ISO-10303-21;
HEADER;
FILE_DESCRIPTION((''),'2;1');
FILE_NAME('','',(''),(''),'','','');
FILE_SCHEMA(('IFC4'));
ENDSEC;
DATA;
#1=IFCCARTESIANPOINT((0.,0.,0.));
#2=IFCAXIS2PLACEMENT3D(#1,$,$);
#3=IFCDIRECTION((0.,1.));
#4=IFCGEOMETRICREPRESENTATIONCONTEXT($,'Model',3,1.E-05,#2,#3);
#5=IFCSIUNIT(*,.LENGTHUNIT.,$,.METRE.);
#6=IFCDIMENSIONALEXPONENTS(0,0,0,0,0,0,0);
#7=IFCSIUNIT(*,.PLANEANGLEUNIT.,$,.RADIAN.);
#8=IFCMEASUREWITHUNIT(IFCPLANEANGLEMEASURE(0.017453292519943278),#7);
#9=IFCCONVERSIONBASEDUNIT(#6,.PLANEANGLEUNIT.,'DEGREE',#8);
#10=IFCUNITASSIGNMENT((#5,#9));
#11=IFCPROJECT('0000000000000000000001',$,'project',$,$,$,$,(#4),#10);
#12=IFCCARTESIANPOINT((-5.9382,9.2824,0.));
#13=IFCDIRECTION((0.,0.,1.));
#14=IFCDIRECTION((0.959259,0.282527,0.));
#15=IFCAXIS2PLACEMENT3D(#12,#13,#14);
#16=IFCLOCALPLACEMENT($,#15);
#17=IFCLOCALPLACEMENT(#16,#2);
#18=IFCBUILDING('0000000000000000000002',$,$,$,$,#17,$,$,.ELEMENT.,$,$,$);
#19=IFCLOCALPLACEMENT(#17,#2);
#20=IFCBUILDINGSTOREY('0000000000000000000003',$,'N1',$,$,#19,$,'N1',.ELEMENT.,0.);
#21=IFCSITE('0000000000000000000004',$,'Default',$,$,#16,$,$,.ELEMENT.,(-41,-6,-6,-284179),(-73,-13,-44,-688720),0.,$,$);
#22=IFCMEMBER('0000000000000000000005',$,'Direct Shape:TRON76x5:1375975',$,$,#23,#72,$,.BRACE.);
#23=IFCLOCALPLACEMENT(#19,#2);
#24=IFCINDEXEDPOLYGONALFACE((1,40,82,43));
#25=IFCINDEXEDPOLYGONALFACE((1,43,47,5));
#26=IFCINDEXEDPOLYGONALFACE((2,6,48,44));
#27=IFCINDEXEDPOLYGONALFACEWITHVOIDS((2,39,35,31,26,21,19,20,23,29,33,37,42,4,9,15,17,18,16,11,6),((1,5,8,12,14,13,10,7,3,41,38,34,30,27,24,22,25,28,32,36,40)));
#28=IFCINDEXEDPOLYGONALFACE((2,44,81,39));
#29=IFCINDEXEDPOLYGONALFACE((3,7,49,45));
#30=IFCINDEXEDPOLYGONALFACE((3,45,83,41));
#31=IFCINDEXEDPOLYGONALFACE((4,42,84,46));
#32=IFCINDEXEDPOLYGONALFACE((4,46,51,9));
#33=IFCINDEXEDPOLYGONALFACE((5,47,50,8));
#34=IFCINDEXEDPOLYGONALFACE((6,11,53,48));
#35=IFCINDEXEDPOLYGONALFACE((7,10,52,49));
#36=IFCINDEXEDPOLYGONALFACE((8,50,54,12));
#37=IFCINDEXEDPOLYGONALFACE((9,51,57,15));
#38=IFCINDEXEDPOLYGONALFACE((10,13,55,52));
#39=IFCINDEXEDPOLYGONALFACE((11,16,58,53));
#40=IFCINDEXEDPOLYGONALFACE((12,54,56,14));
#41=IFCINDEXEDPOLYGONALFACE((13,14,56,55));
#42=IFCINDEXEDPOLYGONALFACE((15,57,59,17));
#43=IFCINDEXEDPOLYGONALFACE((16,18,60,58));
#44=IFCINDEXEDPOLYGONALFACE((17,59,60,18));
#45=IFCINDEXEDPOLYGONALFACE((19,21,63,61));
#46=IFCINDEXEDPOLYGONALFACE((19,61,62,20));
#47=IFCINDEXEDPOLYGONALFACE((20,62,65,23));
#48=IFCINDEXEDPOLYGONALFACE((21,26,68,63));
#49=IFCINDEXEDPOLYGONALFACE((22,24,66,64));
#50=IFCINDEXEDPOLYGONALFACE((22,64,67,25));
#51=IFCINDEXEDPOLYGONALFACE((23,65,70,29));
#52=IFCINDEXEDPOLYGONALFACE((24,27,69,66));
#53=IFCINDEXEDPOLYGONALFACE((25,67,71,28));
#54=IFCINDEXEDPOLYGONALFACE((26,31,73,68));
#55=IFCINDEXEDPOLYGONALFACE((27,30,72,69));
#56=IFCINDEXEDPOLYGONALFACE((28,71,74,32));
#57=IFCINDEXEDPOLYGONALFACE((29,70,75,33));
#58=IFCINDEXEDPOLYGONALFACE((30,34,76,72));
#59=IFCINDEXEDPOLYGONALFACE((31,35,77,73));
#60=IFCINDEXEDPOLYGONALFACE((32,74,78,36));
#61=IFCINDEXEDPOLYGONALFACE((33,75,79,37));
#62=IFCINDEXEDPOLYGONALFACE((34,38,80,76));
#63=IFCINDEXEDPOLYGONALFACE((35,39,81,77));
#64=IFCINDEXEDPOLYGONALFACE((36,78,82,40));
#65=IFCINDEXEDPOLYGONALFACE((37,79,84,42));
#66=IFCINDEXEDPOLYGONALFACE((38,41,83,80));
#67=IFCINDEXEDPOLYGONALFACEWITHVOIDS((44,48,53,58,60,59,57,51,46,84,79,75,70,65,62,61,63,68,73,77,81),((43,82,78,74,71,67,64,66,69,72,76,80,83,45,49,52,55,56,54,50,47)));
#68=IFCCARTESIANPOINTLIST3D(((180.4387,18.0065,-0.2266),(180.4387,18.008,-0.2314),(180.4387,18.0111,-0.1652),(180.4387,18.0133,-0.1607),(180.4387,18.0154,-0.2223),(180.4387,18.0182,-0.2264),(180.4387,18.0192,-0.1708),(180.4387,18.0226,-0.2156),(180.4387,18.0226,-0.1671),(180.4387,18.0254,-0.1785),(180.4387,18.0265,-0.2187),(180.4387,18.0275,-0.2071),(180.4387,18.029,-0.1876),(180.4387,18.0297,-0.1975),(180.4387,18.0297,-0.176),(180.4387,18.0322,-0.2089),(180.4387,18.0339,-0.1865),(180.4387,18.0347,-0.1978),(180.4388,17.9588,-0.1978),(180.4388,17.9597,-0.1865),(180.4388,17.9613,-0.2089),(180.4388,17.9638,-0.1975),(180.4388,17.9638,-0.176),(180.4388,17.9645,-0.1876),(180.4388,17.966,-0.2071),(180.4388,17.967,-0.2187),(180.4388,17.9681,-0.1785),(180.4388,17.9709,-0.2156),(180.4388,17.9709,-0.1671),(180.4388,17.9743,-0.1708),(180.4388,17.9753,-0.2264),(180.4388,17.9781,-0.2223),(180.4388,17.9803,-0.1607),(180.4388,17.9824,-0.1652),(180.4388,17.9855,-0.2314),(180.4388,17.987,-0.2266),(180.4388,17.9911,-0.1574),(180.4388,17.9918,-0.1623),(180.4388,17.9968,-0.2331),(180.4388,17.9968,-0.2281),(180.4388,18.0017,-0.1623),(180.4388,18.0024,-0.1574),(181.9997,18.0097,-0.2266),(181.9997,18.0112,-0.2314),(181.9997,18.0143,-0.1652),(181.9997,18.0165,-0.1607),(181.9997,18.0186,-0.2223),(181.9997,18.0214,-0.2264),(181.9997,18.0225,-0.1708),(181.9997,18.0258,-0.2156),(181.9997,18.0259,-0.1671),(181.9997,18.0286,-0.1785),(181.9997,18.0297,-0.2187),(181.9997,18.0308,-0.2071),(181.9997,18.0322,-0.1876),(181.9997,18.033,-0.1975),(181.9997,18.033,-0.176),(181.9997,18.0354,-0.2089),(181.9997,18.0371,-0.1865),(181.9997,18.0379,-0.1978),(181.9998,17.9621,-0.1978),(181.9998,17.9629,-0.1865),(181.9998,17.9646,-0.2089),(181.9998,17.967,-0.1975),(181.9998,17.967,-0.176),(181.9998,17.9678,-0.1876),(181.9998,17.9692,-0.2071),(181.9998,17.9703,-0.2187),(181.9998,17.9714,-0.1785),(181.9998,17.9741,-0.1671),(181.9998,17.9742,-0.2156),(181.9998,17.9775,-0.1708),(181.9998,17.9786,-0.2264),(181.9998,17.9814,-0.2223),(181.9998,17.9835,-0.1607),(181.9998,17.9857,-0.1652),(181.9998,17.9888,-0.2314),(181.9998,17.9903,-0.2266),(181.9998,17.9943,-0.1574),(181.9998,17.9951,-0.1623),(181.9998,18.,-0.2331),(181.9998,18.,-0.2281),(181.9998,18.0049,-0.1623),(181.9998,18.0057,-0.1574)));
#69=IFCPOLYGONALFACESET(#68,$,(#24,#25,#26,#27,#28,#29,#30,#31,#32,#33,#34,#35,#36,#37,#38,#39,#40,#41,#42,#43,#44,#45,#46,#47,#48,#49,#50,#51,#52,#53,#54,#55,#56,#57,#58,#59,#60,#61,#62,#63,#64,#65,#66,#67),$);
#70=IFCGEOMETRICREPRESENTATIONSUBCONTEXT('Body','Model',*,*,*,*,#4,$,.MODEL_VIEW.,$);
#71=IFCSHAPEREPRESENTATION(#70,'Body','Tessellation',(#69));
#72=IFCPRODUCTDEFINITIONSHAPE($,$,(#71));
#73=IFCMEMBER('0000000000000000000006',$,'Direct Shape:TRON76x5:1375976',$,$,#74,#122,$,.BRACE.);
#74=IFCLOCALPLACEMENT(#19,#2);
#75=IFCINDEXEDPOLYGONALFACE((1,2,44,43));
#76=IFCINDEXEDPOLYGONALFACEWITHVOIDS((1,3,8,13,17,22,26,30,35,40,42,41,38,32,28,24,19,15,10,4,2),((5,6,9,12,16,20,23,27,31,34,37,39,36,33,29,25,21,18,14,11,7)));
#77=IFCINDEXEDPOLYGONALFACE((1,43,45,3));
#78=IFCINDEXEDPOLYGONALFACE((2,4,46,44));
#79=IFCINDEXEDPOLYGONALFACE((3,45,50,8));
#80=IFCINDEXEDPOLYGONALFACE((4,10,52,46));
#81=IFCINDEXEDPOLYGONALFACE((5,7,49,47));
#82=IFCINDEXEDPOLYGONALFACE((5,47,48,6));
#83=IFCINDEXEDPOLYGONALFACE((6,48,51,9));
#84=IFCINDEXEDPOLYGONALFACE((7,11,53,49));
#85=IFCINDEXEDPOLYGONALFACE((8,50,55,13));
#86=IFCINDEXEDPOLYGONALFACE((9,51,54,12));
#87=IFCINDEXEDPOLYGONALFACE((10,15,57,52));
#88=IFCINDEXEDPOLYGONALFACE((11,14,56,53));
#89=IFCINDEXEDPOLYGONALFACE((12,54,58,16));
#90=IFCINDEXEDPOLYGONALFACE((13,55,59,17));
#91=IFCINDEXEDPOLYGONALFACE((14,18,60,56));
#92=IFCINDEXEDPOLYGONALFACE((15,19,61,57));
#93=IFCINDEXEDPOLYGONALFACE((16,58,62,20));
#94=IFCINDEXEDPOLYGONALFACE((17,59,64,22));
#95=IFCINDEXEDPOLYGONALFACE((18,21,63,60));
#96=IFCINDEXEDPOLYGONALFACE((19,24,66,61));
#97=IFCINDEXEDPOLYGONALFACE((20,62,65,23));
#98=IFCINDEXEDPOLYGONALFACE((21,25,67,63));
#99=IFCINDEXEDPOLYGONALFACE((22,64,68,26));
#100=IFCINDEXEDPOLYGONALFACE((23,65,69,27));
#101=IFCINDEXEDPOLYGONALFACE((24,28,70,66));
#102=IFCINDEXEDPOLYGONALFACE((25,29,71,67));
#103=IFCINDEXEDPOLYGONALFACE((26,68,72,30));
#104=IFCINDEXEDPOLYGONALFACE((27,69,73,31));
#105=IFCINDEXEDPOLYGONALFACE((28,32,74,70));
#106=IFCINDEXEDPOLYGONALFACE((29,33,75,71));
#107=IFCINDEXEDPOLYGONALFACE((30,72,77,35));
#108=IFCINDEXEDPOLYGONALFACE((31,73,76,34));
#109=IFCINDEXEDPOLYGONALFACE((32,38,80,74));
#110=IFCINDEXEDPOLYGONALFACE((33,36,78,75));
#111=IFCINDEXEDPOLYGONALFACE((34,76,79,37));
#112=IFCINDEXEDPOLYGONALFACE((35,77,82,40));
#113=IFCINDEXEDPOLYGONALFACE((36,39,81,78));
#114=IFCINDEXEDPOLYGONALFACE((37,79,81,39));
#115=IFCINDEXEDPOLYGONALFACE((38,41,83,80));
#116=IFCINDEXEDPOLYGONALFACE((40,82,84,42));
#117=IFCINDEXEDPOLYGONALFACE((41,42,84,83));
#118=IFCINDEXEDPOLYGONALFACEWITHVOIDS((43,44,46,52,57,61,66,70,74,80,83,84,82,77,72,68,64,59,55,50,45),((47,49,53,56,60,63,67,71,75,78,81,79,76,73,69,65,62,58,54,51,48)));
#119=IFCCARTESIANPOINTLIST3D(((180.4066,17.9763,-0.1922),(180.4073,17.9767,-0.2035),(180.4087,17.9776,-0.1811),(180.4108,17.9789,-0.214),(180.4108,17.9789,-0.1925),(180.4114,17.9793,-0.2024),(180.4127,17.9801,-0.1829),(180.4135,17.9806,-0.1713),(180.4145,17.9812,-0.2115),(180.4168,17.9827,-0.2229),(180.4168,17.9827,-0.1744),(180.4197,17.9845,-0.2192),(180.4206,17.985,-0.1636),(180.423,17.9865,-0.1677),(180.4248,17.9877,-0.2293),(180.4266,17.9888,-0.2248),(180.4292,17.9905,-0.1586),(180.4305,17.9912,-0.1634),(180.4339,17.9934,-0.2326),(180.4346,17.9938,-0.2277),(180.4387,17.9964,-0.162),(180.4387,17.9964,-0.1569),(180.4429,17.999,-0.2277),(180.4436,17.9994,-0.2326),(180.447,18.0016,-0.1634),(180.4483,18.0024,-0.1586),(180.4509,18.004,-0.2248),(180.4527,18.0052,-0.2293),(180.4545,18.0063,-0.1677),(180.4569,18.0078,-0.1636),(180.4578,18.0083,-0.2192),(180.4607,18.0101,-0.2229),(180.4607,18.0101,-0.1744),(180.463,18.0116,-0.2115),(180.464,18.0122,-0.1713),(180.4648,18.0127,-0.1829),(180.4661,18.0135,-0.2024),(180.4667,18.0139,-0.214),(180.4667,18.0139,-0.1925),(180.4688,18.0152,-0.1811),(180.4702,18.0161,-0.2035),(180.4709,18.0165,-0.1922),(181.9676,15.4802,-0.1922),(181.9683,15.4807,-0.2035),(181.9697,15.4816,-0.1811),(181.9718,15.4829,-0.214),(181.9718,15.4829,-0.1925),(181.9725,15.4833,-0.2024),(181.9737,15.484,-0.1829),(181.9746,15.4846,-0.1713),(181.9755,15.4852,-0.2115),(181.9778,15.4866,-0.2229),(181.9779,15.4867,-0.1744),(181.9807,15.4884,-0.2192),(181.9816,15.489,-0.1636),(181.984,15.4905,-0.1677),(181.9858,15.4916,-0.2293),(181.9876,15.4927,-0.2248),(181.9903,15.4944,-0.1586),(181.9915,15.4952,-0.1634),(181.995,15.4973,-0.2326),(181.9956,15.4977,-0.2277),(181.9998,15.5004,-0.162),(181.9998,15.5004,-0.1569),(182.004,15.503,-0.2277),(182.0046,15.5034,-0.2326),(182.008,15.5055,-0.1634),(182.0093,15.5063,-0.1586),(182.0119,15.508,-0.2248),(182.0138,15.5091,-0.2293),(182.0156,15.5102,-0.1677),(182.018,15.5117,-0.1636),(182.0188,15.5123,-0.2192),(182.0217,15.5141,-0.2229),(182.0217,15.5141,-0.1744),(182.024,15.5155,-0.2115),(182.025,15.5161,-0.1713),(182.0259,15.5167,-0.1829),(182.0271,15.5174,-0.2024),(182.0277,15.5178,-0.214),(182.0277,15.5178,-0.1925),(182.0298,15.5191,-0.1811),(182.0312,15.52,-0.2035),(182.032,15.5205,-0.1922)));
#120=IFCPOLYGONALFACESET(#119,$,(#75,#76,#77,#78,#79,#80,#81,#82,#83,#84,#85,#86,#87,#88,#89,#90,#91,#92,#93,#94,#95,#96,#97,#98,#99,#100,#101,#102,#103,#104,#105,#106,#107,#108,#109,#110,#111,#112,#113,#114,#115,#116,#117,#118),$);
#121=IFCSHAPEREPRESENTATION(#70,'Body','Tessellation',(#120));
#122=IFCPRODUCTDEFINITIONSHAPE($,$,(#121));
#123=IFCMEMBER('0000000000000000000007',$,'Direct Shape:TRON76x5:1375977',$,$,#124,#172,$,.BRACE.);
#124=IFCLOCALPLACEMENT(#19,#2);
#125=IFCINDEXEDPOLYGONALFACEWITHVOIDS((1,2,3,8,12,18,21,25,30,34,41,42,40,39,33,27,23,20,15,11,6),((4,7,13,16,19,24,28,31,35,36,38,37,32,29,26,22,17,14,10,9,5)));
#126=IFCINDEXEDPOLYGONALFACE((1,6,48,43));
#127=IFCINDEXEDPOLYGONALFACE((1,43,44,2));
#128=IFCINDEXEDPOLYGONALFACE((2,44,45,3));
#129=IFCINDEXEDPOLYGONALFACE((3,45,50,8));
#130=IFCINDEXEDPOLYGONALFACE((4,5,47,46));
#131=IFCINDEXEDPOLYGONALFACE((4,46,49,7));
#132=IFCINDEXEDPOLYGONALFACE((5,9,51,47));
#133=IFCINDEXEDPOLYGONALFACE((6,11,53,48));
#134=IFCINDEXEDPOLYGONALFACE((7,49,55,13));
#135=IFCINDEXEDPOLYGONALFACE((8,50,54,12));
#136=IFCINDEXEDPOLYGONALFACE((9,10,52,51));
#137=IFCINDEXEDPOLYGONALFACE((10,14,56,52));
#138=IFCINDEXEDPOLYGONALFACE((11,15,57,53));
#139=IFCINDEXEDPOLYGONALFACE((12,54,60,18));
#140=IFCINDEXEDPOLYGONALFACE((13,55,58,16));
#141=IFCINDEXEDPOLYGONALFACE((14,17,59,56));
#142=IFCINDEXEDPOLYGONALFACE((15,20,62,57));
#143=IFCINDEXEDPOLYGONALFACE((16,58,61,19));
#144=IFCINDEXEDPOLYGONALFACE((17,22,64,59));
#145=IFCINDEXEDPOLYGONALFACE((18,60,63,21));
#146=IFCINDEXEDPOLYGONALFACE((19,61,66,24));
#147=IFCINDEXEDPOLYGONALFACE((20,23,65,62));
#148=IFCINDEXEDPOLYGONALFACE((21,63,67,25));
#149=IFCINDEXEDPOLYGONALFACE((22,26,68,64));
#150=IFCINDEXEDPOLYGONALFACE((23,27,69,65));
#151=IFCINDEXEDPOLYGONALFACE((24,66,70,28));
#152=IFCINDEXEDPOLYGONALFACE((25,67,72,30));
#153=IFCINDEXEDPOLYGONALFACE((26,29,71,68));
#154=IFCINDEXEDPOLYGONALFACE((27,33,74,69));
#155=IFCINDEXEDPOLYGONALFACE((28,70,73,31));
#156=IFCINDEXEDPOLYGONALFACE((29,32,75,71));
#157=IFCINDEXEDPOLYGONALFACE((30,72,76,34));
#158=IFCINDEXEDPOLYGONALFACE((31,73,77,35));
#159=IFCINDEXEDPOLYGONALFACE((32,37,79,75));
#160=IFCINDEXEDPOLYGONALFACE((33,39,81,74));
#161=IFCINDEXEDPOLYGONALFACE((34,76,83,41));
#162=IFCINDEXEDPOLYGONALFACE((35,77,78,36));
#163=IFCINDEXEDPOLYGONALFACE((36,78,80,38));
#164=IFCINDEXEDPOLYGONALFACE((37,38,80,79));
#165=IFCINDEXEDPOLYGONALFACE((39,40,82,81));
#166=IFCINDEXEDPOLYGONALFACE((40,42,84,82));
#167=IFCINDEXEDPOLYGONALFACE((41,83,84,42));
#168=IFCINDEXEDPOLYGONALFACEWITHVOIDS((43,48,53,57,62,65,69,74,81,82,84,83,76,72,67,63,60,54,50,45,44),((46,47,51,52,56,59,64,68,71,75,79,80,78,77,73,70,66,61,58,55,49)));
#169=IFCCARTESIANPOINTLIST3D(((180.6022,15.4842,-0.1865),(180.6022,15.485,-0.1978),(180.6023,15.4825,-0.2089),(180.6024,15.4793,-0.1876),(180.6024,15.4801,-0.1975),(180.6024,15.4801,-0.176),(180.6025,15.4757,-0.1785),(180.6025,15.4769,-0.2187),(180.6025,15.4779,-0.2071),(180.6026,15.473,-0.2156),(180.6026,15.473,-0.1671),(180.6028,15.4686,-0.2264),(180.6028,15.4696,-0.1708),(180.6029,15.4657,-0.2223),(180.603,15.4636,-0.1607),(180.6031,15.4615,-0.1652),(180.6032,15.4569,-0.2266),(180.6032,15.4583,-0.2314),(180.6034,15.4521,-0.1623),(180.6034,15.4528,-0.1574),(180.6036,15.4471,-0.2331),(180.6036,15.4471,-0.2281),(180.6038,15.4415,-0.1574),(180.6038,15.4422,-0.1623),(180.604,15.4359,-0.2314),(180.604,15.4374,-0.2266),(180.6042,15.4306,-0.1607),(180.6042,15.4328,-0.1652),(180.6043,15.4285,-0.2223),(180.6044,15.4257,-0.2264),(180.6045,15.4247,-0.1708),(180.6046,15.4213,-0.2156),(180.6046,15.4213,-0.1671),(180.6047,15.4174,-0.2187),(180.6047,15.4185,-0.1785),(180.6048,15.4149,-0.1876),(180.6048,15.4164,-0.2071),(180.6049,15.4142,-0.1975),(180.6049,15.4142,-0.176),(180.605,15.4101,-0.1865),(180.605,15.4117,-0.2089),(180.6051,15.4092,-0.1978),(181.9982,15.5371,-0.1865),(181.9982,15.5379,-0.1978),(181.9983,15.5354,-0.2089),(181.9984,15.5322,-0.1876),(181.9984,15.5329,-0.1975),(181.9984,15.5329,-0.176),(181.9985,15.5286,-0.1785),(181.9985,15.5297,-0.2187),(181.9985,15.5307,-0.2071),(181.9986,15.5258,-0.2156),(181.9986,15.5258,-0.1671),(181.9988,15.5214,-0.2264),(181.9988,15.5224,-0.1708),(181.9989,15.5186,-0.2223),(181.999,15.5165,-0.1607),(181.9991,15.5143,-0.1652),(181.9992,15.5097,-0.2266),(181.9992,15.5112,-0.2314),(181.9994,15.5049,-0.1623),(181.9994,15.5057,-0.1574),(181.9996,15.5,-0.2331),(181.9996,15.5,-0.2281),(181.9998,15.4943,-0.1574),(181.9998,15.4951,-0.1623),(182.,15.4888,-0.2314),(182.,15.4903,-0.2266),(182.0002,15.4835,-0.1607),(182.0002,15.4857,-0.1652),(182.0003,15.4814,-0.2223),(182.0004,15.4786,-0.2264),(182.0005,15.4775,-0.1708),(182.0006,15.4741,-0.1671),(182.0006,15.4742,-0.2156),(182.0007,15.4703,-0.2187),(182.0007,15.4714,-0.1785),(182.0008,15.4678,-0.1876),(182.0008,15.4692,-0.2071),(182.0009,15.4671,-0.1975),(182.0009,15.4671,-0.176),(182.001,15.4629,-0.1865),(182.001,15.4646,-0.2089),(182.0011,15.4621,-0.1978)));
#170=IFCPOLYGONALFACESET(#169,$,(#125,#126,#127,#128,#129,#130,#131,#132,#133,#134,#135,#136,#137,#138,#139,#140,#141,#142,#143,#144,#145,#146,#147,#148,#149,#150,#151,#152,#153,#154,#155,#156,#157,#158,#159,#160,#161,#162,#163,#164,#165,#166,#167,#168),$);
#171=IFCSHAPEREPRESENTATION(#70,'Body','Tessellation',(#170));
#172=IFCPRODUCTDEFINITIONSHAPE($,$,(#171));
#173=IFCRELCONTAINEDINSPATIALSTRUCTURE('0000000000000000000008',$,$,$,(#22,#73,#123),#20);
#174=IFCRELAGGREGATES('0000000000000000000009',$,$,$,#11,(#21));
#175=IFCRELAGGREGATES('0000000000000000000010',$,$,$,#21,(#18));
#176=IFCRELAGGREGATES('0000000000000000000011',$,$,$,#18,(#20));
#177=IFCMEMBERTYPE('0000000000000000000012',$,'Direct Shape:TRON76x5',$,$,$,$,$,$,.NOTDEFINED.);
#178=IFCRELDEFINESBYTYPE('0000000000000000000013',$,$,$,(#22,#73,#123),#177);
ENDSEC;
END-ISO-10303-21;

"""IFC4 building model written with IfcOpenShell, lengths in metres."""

from ifc_helpers import new_model, entity, si_unit, converted_unit, direction, frame, frame_2d, origin, place, context, subcontext, project, spatial, hollow_circle, extrude, type_object, element, save


model = new_model("IFC4")

# Units and contexts
model_context = context("Model", 3, precision=1e-05, world=origin(), true_north=direction((0.0, 1.0)))
body_context = subcontext(model_context, "Body", "Model", "MODEL_VIEW")
ifc_project = project(units=[si_unit("LENGTHUNIT", "METRE"), converted_unit("PLANEANGLEUNIT", "DEGREE", entity("IfcPlaneAngleMeasure", 0.017453292519943278), si_unit("PLANEANGLEUNIT", "RADIAN"), dimensions=[0, 0, 0, 0, 0, 0, 0])], contexts=[model_context])

# Site, building, storey
site_placement = place(None, frame((-5.9382, 9.2824, 0.0), z_axis=(0.0, 0.0, 1.0), x_axis=(0.959259, 0.282527, 0.0)))
site = spatial("IfcSite", under=ifc_project, at=site_placement, Name="Default", CompositionType="ELEMENT", RefLatitude=(-41, -6, -6, -284179), RefLongitude=(-73, -13, -44, -688720), RefElevation=0.0)
building_placement = place(site_placement, origin())
building = spatial("IfcBuilding", under=site, at=building_placement, CompositionType="ELEMENT")
storey_placement = place(building_placement, origin())
storey = spatial("IfcBuildingStorey", under=building, at=storey_placement, Name="N1", LongName="N1", CompositionType="ELEMENT", Elevation=0.0)

# Members
member_type_1 = type_object("IfcMemberType", Name="Direct Shape:TRON76x5", PredefinedType="NOTDEFINED")
member_1_placement = place(storey_placement, origin())
element("IfcMember", 1, at=member_1_placement, inside=storey, type_object=member_type_1, Name="Direct Shape:TRON76x5:1375975", PredefinedType="BRACE", context=body_context, shape_type="SweptSolid", body=[
    extrude(hollow_circle(Radius=0.0381, WallThickness=0.005, at=frame_2d((0.0, 0.0), x_axis=(1.0, 0.0))), frame((180.4388, 17.9968, -0.195), z_axis=(0.999998, 0.002072, 0.0), x_axis=(0.0, 0.0, -1.0)), (0.0, 0.0, 1.0), 1.561),
])
member_2_placement = place(storey_placement, origin())
element("IfcMember", 2, at=member_2_placement, inside=storey, type_object=member_type_1, Name="Direct Shape:TRON76x5:1375976", PredefinedType="BRACE", context=body_context, shape_type="SweptSolid", body=[
    extrude(hollow_circle(Radius=0.0381, WallThickness=0.005, at=frame_2d((0.0, 0.0), x_axis=(1.0, 0.0))), frame((181.9998, 15.5004, -0.195), z_axis=(-0.530241, 0.847847, 0.0), x_axis=(0.0, 0.0, 1.0)), (0.0, 0.0, 1.0), 2.944),
])
member_3_placement = place(storey_placement, origin())
element("IfcMember", 3, at=member_3_placement, inside=storey, type_object=member_type_1, Name="Direct Shape:TRON76x5:1375977", PredefinedType="BRACE", context=body_context, shape_type="SweptSolid", body=[
    extrude(hollow_circle(Radius=0.0381, WallThickness=0.005, at=frame_2d((0.0, 0.0), x_axis=(1.0, 0.0))), frame((180.6036, 15.4471, -0.195), z_axis=(0.999284, 0.037833, 0.0), x_axis=(0.0, 0.0, -1.0)), (0.0, 0.0, 1.0), 1.397),
])

save(model, "model.ifc")
